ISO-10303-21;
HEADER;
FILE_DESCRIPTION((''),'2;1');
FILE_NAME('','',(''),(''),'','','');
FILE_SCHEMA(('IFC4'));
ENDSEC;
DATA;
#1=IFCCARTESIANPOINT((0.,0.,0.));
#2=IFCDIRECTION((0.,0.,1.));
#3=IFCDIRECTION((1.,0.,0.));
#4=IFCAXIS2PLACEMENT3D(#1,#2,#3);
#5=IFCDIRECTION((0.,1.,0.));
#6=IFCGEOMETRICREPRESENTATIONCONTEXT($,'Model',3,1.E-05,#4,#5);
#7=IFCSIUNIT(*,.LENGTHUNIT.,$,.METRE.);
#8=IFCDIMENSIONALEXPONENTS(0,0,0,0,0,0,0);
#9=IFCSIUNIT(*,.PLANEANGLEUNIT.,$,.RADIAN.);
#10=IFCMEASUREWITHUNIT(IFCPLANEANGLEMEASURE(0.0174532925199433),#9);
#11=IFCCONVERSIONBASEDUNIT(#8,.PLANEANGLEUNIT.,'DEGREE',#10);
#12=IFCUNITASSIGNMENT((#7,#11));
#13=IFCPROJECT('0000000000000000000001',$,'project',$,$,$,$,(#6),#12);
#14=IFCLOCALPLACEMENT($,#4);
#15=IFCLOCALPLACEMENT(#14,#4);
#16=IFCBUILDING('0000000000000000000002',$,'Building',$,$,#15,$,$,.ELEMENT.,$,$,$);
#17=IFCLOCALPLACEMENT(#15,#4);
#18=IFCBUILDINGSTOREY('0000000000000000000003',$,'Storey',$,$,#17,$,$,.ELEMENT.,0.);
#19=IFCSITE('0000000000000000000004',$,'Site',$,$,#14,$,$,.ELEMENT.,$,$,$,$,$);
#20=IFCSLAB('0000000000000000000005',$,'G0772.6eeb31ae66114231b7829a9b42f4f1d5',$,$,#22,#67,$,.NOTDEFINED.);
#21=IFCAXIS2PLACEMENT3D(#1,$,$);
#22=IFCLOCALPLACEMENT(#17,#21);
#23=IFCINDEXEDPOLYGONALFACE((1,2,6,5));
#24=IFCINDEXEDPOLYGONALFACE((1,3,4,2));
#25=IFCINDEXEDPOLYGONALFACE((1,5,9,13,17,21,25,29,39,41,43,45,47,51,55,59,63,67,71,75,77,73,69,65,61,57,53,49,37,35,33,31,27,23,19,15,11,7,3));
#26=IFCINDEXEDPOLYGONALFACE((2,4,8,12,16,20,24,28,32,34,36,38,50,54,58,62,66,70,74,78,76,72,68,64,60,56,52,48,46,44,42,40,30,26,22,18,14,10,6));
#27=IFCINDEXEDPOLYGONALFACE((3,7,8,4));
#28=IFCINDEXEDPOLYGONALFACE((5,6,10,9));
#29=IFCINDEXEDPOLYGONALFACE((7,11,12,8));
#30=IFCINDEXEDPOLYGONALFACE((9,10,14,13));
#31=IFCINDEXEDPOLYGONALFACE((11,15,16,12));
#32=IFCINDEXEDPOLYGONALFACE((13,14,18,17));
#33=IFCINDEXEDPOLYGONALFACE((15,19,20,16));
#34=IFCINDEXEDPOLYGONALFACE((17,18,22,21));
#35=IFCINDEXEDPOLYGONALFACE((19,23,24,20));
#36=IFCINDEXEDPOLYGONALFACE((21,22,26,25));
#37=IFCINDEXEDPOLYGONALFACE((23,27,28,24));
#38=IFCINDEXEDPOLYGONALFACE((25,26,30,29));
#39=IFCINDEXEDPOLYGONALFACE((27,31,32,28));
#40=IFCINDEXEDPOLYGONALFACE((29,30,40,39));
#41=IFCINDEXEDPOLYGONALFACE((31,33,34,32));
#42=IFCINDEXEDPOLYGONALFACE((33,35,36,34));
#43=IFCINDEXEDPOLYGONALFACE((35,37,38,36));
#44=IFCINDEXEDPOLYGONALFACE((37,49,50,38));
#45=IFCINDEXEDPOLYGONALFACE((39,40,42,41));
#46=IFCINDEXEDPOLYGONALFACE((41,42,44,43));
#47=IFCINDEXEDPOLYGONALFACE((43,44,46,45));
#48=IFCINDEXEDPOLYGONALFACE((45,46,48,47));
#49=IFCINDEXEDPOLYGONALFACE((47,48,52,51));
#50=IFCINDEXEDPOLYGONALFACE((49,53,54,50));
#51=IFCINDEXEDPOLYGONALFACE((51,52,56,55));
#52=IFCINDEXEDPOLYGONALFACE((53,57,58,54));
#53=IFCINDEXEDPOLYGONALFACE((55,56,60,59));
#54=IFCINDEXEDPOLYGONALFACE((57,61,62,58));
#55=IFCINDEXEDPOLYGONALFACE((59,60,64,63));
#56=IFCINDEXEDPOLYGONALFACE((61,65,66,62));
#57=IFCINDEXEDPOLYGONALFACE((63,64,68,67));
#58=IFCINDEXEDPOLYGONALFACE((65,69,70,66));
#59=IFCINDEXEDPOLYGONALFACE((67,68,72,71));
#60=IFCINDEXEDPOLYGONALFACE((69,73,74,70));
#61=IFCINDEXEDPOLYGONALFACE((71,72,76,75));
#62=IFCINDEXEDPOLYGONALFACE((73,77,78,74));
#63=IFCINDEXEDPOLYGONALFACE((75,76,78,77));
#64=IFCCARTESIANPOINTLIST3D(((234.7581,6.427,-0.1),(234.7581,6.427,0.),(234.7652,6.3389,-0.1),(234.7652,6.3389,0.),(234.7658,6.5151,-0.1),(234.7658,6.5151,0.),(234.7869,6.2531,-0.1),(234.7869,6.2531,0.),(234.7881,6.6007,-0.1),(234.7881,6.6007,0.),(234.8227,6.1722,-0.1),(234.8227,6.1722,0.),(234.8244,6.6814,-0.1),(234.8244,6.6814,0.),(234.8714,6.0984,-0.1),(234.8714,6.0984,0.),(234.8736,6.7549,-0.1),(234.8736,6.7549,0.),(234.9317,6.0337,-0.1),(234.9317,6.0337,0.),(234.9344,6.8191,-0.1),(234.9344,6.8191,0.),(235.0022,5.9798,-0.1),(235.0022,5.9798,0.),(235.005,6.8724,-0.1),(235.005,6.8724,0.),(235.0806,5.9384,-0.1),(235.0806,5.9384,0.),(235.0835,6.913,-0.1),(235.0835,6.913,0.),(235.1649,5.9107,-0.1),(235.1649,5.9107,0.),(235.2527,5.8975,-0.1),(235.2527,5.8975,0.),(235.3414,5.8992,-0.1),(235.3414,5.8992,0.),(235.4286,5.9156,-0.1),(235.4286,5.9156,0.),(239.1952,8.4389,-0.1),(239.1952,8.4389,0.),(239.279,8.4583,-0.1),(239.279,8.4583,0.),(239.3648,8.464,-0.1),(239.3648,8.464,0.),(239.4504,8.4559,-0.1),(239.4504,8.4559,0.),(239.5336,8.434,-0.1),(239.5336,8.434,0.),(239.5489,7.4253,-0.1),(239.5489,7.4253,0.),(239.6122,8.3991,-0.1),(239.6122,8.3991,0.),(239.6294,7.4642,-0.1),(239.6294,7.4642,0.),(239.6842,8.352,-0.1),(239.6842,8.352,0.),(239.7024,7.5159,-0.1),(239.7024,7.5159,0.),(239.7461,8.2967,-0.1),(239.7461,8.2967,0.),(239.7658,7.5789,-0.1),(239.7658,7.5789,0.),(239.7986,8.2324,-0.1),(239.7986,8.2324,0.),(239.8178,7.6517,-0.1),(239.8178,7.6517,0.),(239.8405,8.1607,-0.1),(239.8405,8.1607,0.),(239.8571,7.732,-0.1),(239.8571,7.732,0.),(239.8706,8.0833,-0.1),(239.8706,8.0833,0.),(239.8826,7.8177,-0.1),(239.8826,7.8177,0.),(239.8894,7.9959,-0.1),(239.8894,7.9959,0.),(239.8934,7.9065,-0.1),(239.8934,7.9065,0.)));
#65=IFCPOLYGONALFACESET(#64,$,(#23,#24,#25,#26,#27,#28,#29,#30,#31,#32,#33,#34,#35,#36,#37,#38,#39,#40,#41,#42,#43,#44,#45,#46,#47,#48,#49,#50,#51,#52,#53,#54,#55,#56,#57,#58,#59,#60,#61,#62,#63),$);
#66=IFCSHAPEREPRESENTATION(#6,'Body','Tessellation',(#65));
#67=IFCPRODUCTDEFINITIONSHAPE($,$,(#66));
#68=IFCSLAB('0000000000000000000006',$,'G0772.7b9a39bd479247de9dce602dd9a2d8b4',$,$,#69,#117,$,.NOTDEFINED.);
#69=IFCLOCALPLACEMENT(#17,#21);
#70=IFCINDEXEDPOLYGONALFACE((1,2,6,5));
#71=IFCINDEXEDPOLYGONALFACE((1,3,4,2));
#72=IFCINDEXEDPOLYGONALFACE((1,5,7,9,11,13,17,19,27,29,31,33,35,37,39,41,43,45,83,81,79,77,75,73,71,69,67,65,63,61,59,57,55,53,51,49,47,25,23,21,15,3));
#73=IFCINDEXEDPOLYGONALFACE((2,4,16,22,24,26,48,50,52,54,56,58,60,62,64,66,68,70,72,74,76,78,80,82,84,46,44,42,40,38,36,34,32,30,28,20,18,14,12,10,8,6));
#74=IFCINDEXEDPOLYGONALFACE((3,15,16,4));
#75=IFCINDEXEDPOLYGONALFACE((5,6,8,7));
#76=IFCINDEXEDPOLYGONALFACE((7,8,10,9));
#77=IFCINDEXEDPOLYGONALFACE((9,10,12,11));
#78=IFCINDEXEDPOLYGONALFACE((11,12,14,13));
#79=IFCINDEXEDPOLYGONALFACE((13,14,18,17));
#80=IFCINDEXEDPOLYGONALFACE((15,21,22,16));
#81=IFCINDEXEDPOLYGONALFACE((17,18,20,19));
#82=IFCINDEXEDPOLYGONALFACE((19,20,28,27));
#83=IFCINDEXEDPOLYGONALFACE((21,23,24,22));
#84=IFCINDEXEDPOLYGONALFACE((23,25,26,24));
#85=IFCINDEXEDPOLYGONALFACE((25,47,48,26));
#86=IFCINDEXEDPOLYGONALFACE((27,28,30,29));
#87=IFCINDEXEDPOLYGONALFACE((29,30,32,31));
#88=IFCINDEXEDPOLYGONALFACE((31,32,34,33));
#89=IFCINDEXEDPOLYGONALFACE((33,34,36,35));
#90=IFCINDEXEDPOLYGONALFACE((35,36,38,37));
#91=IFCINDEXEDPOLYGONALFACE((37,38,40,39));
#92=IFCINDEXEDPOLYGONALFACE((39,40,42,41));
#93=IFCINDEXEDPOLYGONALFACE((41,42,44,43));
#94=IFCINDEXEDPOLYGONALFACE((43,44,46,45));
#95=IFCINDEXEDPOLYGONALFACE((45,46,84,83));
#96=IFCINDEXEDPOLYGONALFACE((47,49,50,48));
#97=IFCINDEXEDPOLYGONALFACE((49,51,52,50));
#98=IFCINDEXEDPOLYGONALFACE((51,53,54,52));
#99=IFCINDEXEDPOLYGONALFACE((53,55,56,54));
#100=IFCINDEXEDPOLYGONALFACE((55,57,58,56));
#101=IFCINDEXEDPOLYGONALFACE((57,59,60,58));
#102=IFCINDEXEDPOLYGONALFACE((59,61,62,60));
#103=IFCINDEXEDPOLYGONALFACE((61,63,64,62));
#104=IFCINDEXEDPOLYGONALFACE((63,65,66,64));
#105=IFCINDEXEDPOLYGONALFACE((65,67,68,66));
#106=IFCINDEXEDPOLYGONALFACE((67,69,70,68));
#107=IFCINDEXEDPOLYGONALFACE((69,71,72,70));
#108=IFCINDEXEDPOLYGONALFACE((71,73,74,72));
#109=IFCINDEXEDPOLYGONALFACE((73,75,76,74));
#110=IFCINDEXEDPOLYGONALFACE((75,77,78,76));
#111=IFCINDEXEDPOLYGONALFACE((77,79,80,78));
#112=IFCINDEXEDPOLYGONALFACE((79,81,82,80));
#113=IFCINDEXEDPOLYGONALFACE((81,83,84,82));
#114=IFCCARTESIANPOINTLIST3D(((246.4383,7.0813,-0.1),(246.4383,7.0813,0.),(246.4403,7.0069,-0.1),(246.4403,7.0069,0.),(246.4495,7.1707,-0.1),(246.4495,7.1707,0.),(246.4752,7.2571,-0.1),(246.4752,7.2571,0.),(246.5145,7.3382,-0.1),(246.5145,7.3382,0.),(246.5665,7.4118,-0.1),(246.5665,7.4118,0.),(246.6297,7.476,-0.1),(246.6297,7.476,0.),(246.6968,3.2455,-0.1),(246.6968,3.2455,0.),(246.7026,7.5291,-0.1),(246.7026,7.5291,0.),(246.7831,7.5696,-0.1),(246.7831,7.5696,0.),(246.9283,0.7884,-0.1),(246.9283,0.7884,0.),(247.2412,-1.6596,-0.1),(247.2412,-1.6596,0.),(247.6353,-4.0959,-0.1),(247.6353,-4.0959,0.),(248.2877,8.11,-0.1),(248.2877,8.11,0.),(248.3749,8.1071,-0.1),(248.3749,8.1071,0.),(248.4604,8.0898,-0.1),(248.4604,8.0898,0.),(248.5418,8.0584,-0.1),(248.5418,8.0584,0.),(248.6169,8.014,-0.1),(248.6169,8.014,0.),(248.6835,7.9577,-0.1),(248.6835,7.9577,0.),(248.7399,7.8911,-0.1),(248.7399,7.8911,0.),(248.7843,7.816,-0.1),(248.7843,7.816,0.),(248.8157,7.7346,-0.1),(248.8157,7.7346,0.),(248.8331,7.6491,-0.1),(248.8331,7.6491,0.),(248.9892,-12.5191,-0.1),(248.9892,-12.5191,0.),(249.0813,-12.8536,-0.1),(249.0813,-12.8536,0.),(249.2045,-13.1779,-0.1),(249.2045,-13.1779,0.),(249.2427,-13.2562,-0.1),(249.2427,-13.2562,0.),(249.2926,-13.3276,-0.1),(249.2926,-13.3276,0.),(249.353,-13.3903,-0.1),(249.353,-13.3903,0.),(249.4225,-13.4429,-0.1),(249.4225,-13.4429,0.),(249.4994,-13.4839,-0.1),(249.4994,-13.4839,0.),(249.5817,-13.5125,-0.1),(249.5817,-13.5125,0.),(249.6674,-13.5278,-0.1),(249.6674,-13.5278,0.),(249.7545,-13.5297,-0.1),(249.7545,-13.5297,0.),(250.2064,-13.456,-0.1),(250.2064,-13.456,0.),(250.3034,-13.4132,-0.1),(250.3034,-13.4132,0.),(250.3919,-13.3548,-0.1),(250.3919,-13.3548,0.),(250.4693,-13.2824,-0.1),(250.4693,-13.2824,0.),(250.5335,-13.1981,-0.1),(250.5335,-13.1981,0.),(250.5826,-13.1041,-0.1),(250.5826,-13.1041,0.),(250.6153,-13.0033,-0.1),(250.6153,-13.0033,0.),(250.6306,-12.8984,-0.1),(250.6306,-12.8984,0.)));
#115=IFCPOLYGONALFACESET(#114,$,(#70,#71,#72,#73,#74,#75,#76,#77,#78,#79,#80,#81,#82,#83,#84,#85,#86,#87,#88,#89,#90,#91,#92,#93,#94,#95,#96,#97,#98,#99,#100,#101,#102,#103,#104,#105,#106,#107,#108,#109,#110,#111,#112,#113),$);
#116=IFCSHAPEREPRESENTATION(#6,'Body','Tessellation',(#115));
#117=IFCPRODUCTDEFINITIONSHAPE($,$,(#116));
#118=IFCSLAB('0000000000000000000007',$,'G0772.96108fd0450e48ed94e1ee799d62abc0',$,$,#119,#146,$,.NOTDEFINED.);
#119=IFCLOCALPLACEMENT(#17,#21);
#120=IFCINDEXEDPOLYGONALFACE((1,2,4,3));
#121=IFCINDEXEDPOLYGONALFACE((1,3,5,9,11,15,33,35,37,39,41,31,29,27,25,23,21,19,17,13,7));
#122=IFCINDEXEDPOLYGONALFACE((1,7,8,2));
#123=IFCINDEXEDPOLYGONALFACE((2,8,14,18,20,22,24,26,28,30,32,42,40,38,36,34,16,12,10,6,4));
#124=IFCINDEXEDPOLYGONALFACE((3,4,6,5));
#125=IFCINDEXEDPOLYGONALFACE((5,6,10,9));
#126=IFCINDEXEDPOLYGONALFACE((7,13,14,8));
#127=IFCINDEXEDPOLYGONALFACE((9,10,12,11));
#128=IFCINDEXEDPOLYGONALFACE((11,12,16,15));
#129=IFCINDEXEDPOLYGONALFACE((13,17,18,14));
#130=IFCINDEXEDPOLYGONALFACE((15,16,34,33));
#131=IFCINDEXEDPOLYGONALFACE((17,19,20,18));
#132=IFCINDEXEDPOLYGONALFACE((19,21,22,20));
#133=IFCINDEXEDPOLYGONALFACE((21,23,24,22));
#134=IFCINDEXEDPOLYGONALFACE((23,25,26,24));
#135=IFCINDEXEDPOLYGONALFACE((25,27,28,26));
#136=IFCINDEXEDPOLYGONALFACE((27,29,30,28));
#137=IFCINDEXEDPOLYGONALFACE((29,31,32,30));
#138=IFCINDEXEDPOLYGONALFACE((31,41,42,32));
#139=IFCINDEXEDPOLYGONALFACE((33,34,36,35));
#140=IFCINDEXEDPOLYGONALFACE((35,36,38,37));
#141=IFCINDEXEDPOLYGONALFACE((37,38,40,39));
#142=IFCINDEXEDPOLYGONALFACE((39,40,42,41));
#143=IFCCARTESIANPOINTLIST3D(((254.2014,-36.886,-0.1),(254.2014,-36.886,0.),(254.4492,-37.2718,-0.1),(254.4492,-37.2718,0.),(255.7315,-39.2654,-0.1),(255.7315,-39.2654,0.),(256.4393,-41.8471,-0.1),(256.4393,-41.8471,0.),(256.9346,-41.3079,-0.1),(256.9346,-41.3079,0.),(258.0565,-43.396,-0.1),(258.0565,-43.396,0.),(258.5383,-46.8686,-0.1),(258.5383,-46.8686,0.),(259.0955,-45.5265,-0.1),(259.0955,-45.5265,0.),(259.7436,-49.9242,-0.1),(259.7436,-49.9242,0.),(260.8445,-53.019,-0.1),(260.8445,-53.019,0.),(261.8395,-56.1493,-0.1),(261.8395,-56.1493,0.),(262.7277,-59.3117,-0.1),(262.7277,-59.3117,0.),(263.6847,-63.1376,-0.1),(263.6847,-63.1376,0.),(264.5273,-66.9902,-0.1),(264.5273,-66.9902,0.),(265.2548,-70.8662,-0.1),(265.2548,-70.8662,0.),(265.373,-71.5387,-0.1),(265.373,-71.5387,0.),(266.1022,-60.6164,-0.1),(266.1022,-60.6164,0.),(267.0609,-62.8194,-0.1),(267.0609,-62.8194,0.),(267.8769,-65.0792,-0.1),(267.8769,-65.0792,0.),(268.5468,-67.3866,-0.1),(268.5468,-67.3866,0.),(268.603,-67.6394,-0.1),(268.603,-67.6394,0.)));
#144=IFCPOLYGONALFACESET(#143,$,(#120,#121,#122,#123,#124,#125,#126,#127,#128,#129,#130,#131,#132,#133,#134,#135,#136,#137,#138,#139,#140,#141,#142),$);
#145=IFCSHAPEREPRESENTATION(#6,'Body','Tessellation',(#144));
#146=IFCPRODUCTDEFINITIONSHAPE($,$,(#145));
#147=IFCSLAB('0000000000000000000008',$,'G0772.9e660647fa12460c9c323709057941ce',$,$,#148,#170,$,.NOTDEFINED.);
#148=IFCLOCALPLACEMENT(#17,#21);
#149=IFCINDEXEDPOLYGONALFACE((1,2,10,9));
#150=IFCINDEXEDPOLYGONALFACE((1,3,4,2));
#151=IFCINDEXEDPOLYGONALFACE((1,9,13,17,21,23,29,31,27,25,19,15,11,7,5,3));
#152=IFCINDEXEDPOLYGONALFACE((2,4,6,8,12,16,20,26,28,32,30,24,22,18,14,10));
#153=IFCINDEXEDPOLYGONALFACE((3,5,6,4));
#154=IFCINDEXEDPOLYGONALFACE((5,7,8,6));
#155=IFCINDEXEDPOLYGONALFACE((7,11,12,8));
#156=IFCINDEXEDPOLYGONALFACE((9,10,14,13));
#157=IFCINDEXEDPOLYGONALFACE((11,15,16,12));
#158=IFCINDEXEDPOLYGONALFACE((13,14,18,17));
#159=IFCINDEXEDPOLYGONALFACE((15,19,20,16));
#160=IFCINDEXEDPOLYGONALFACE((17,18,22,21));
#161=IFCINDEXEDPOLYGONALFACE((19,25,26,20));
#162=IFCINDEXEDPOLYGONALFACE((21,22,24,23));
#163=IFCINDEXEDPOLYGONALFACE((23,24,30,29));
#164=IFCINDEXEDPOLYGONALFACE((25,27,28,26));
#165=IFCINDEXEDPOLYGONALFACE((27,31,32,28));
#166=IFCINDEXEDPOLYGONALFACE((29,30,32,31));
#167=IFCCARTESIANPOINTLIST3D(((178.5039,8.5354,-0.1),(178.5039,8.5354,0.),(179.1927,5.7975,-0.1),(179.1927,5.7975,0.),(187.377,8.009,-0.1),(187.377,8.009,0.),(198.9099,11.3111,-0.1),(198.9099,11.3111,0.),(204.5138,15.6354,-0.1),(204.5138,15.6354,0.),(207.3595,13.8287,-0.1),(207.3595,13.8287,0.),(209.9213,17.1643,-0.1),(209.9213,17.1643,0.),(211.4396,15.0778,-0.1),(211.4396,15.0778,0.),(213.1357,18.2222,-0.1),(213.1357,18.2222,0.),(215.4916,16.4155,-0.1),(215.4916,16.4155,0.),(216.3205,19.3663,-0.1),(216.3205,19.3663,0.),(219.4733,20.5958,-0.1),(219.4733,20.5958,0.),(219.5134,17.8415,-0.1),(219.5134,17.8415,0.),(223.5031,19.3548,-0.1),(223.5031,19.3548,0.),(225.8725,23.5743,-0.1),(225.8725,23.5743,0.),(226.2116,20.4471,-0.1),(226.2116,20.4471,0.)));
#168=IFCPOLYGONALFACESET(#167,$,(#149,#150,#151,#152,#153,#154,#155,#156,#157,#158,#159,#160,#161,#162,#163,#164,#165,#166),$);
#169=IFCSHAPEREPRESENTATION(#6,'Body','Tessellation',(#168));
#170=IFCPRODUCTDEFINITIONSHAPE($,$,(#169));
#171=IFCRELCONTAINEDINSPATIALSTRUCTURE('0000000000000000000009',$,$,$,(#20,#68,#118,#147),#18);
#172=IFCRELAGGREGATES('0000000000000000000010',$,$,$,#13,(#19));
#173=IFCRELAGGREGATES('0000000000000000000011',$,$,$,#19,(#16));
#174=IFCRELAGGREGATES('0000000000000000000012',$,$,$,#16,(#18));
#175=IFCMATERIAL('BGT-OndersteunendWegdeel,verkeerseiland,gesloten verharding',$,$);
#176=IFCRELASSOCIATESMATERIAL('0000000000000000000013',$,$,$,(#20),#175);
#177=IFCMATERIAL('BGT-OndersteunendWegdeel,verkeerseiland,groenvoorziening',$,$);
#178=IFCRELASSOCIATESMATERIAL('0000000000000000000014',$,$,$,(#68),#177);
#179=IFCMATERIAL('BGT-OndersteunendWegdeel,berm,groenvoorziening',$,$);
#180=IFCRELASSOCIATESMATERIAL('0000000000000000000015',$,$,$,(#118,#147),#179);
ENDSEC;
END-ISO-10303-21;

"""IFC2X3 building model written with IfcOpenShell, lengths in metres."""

from ifc_helpers import new_model, entity, si_unit, converted_unit, direction, frame, origin_with_axes, place, context, project, spatial, polyline, outline, extrude, material, element, save


model = new_model("IFC2X3")

# Units and contexts
model_context = context("Model", 3, precision=1e-05, world=origin_with_axes(), true_north=direction((0.0, 1.0, 0.0)))
ifc_project = project(units=[si_unit("LENGTHUNIT", "METRE"), converted_unit("PLANEANGLEUNIT", "DEGREE", entity("IfcPlaneAngleMeasure", 0.0174532925199433), si_unit("PLANEANGLEUNIT", "RADIAN"), dimensions=[0, 0, 0, 0, 0, 0, 0])], contexts=[model_context])

# Site, building, storey
site_placement = place(None, origin_with_axes())
site = spatial("IfcSite", under=ifc_project, at=site_placement, Name="Site", CompositionType="ELEMENT")
building_placement = place(site_placement, origin_with_axes())
building = spatial("IfcBuilding", under=site, at=building_placement, Name="Building", CompositionType="ELEMENT")
storey_placement = place(building_placement, origin_with_axes())
storey = spatial("IfcBuildingStorey", under=building, at=storey_placement, Name="Storey", CompositionType="ELEMENT", Elevation=0.0)

# Slabs
ifc_material_1 = material(Name="BGT-OndersteunendWegdeel,berm,groenvoorziening")
ifc_material_2 = material(Name="BGT-OndersteunendWegdeel,verkeerseiland,gesloten verharding")
ifc_material_3 = material(Name="BGT-OndersteunendWegdeel,verkeerseiland,groenvoorziening")
slab_1_placement = place(storey_placement, frame((0.0, 0.0, -0.1), z_axis=(0.0, 0.0, 1.0), x_axis=(1.0, 0.0, 0.0)))
element("IfcSlab", 1, at=slab_1_placement, inside=storey, material=ifc_material_2, Name="G0772.6eeb31ae66114231b7829a9b42f4f1d5", PredefinedType="NOTDEFINED", context=model_context, shape_type="SweptSolid", body=[
    extrude(outline(polyline([(239.1952, 8.4389), (239.279, 8.4583), (239.3648, 8.464), (239.4504, 8.4559), (239.5336, 8.434), (239.6122, 8.3991), (239.6842, 8.352), (239.7461, 8.2967), (239.7986, 8.2324), (239.8405, 8.1607), (239.8706, 8.0833), (239.8894, 7.9959), (239.8934, 7.9065), (239.8826, 7.8177), (239.8571, 7.732), (239.8178, 7.6517), (239.7658, 7.5789), (239.7024, 7.5159), (239.6294, 7.4642), (239.5489, 7.4253), (235.4286, 5.9156), (235.3414, 5.8992), (235.2527, 5.8975), (235.1649, 5.9107), (235.0806, 5.9384), (235.0022, 5.9798), (234.9317, 6.0337), (234.8714, 6.0984), (234.8227, 6.1722), (234.7869, 6.2531), (234.7652, 6.3389), (234.7581, 6.427), (234.7658, 6.5151), (234.7881, 6.6007), (234.8244, 6.6814), (234.8736, 6.7549), (234.9344, 6.8191), (235.005, 6.8724), (235.0835, 6.913), (239.1952, 8.4389)])), origin_with_axes(), (0.0, 0.0, 1.0), 0.1),
])
slab_2_placement = place(storey_placement, frame((0.0, 0.0, -0.1), z_axis=(0.0, 0.0, 1.0), x_axis=(1.0, 0.0, 0.0)))
element("IfcSlab", 2, at=slab_2_placement, inside=storey, material=ifc_material_3, Name="G0772.7b9a39bd479247de9dce602dd9a2d8b4", PredefinedType="NOTDEFINED", context=model_context, shape_type="SweptSolid", body=[
    extrude(outline(polyline([(250.6306, -12.8984), (250.6153, -13.0033), (250.5826, -13.1041), (250.5335, -13.1981), (250.4693, -13.2824), (250.3919, -13.3548), (250.3034, -13.4132), (250.2064, -13.456), (249.7545, -13.5297), (249.6674, -13.5278), (249.5817, -13.5125), (249.4994, -13.4839), (249.4225, -13.4429), (249.353, -13.3903), (249.2926, -13.3276), (249.2427, -13.2562), (249.2045, -13.1779), (249.0813, -12.8536), (248.9892, -12.5191), (247.6353, -4.0959), (247.2412, -1.6596), (246.9283, 0.7884), (246.6968, 3.2455), (246.4403, 7.0069), (246.4383, 7.0813), (246.4495, 7.1707), (246.4752, 7.2571), (246.5145, 7.3382), (246.5665, 7.4118), (246.6297, 7.476), (246.7026, 7.5291), (246.7831, 7.5696), (248.2877, 8.11), (248.3749, 8.1071), (248.4604, 8.0898), (248.5418, 8.0584), (248.6169, 8.014), (248.6835, 7.9577), (248.7399, 7.8911), (248.7843, 7.816), (248.8157, 7.7346), (248.8331, 7.6491), (250.6306, -12.8984)])), origin_with_axes(), (0.0, 0.0, 1.0), 0.1),
])
slab_3_placement = place(storey_placement, frame((0.0, 0.0, -0.1), z_axis=(0.0, 0.0, 1.0), x_axis=(1.0, 0.0, 0.0)))
element("IfcSlab", 3, at=slab_3_placement, inside=storey, material=ifc_material_1, Name="G0772.96108fd0450e48ed94e1ee799d62abc0", PredefinedType="NOTDEFINED", context=model_context, shape_type="SweptSolid", body=[
    extrude(outline(polyline([(265.2548, -70.8662), (264.5273, -66.9902), (263.6847, -63.1376), (262.7277, -59.3117), (261.8395, -56.1493), (260.8445, -53.019), (259.7436, -49.9242), (258.5383, -46.8686), (256.4393, -41.8471), (254.2014, -36.886), (254.4492, -37.2718), (255.7315, -39.2654), (256.9346, -41.3079), (258.0565, -43.396), (259.0955, -45.5265), (266.1022, -60.6164), (267.0609, -62.8194), (267.8769, -65.0792), (268.5468, -67.3866), (268.603, -67.6394), (265.373, -71.5387), (265.2548, -70.8662)])), origin_with_axes(), (0.0, 0.0, 1.0), 0.1),
])
slab_4_placement = place(storey_placement, frame((0.0, 0.0, -0.1), z_axis=(0.0, 0.0, 1.0), x_axis=(1.0, 0.0, 0.0)))
element("IfcSlab", 4, at=slab_4_placement, inside=storey, material=ifc_material_1, Name="G0772.9e660647fa12460c9c323709057941ce", PredefinedType="NOTDEFINED", context=model_context, shape_type="SweptSolid", body=[
    extrude(outline(polyline([(209.9213, 17.1643), (213.1357, 18.2222), (216.3205, 19.3663), (219.4733, 20.5958), (225.8725, 23.5743), (226.2116, 20.4471), (223.5031, 19.3548), (219.5134, 17.8415), (215.4916, 16.4155), (211.4396, 15.0778), (207.3595, 13.8287), (198.9099, 11.3111), (187.377, 8.009), (179.1927, 5.7975), (178.5039, 8.5354), (204.5138, 15.6354), (209.9213, 17.1643)])), origin_with_axes(), (0.0, 0.0, 1.0), 0.1),
])

save(model, "model.ifc")
